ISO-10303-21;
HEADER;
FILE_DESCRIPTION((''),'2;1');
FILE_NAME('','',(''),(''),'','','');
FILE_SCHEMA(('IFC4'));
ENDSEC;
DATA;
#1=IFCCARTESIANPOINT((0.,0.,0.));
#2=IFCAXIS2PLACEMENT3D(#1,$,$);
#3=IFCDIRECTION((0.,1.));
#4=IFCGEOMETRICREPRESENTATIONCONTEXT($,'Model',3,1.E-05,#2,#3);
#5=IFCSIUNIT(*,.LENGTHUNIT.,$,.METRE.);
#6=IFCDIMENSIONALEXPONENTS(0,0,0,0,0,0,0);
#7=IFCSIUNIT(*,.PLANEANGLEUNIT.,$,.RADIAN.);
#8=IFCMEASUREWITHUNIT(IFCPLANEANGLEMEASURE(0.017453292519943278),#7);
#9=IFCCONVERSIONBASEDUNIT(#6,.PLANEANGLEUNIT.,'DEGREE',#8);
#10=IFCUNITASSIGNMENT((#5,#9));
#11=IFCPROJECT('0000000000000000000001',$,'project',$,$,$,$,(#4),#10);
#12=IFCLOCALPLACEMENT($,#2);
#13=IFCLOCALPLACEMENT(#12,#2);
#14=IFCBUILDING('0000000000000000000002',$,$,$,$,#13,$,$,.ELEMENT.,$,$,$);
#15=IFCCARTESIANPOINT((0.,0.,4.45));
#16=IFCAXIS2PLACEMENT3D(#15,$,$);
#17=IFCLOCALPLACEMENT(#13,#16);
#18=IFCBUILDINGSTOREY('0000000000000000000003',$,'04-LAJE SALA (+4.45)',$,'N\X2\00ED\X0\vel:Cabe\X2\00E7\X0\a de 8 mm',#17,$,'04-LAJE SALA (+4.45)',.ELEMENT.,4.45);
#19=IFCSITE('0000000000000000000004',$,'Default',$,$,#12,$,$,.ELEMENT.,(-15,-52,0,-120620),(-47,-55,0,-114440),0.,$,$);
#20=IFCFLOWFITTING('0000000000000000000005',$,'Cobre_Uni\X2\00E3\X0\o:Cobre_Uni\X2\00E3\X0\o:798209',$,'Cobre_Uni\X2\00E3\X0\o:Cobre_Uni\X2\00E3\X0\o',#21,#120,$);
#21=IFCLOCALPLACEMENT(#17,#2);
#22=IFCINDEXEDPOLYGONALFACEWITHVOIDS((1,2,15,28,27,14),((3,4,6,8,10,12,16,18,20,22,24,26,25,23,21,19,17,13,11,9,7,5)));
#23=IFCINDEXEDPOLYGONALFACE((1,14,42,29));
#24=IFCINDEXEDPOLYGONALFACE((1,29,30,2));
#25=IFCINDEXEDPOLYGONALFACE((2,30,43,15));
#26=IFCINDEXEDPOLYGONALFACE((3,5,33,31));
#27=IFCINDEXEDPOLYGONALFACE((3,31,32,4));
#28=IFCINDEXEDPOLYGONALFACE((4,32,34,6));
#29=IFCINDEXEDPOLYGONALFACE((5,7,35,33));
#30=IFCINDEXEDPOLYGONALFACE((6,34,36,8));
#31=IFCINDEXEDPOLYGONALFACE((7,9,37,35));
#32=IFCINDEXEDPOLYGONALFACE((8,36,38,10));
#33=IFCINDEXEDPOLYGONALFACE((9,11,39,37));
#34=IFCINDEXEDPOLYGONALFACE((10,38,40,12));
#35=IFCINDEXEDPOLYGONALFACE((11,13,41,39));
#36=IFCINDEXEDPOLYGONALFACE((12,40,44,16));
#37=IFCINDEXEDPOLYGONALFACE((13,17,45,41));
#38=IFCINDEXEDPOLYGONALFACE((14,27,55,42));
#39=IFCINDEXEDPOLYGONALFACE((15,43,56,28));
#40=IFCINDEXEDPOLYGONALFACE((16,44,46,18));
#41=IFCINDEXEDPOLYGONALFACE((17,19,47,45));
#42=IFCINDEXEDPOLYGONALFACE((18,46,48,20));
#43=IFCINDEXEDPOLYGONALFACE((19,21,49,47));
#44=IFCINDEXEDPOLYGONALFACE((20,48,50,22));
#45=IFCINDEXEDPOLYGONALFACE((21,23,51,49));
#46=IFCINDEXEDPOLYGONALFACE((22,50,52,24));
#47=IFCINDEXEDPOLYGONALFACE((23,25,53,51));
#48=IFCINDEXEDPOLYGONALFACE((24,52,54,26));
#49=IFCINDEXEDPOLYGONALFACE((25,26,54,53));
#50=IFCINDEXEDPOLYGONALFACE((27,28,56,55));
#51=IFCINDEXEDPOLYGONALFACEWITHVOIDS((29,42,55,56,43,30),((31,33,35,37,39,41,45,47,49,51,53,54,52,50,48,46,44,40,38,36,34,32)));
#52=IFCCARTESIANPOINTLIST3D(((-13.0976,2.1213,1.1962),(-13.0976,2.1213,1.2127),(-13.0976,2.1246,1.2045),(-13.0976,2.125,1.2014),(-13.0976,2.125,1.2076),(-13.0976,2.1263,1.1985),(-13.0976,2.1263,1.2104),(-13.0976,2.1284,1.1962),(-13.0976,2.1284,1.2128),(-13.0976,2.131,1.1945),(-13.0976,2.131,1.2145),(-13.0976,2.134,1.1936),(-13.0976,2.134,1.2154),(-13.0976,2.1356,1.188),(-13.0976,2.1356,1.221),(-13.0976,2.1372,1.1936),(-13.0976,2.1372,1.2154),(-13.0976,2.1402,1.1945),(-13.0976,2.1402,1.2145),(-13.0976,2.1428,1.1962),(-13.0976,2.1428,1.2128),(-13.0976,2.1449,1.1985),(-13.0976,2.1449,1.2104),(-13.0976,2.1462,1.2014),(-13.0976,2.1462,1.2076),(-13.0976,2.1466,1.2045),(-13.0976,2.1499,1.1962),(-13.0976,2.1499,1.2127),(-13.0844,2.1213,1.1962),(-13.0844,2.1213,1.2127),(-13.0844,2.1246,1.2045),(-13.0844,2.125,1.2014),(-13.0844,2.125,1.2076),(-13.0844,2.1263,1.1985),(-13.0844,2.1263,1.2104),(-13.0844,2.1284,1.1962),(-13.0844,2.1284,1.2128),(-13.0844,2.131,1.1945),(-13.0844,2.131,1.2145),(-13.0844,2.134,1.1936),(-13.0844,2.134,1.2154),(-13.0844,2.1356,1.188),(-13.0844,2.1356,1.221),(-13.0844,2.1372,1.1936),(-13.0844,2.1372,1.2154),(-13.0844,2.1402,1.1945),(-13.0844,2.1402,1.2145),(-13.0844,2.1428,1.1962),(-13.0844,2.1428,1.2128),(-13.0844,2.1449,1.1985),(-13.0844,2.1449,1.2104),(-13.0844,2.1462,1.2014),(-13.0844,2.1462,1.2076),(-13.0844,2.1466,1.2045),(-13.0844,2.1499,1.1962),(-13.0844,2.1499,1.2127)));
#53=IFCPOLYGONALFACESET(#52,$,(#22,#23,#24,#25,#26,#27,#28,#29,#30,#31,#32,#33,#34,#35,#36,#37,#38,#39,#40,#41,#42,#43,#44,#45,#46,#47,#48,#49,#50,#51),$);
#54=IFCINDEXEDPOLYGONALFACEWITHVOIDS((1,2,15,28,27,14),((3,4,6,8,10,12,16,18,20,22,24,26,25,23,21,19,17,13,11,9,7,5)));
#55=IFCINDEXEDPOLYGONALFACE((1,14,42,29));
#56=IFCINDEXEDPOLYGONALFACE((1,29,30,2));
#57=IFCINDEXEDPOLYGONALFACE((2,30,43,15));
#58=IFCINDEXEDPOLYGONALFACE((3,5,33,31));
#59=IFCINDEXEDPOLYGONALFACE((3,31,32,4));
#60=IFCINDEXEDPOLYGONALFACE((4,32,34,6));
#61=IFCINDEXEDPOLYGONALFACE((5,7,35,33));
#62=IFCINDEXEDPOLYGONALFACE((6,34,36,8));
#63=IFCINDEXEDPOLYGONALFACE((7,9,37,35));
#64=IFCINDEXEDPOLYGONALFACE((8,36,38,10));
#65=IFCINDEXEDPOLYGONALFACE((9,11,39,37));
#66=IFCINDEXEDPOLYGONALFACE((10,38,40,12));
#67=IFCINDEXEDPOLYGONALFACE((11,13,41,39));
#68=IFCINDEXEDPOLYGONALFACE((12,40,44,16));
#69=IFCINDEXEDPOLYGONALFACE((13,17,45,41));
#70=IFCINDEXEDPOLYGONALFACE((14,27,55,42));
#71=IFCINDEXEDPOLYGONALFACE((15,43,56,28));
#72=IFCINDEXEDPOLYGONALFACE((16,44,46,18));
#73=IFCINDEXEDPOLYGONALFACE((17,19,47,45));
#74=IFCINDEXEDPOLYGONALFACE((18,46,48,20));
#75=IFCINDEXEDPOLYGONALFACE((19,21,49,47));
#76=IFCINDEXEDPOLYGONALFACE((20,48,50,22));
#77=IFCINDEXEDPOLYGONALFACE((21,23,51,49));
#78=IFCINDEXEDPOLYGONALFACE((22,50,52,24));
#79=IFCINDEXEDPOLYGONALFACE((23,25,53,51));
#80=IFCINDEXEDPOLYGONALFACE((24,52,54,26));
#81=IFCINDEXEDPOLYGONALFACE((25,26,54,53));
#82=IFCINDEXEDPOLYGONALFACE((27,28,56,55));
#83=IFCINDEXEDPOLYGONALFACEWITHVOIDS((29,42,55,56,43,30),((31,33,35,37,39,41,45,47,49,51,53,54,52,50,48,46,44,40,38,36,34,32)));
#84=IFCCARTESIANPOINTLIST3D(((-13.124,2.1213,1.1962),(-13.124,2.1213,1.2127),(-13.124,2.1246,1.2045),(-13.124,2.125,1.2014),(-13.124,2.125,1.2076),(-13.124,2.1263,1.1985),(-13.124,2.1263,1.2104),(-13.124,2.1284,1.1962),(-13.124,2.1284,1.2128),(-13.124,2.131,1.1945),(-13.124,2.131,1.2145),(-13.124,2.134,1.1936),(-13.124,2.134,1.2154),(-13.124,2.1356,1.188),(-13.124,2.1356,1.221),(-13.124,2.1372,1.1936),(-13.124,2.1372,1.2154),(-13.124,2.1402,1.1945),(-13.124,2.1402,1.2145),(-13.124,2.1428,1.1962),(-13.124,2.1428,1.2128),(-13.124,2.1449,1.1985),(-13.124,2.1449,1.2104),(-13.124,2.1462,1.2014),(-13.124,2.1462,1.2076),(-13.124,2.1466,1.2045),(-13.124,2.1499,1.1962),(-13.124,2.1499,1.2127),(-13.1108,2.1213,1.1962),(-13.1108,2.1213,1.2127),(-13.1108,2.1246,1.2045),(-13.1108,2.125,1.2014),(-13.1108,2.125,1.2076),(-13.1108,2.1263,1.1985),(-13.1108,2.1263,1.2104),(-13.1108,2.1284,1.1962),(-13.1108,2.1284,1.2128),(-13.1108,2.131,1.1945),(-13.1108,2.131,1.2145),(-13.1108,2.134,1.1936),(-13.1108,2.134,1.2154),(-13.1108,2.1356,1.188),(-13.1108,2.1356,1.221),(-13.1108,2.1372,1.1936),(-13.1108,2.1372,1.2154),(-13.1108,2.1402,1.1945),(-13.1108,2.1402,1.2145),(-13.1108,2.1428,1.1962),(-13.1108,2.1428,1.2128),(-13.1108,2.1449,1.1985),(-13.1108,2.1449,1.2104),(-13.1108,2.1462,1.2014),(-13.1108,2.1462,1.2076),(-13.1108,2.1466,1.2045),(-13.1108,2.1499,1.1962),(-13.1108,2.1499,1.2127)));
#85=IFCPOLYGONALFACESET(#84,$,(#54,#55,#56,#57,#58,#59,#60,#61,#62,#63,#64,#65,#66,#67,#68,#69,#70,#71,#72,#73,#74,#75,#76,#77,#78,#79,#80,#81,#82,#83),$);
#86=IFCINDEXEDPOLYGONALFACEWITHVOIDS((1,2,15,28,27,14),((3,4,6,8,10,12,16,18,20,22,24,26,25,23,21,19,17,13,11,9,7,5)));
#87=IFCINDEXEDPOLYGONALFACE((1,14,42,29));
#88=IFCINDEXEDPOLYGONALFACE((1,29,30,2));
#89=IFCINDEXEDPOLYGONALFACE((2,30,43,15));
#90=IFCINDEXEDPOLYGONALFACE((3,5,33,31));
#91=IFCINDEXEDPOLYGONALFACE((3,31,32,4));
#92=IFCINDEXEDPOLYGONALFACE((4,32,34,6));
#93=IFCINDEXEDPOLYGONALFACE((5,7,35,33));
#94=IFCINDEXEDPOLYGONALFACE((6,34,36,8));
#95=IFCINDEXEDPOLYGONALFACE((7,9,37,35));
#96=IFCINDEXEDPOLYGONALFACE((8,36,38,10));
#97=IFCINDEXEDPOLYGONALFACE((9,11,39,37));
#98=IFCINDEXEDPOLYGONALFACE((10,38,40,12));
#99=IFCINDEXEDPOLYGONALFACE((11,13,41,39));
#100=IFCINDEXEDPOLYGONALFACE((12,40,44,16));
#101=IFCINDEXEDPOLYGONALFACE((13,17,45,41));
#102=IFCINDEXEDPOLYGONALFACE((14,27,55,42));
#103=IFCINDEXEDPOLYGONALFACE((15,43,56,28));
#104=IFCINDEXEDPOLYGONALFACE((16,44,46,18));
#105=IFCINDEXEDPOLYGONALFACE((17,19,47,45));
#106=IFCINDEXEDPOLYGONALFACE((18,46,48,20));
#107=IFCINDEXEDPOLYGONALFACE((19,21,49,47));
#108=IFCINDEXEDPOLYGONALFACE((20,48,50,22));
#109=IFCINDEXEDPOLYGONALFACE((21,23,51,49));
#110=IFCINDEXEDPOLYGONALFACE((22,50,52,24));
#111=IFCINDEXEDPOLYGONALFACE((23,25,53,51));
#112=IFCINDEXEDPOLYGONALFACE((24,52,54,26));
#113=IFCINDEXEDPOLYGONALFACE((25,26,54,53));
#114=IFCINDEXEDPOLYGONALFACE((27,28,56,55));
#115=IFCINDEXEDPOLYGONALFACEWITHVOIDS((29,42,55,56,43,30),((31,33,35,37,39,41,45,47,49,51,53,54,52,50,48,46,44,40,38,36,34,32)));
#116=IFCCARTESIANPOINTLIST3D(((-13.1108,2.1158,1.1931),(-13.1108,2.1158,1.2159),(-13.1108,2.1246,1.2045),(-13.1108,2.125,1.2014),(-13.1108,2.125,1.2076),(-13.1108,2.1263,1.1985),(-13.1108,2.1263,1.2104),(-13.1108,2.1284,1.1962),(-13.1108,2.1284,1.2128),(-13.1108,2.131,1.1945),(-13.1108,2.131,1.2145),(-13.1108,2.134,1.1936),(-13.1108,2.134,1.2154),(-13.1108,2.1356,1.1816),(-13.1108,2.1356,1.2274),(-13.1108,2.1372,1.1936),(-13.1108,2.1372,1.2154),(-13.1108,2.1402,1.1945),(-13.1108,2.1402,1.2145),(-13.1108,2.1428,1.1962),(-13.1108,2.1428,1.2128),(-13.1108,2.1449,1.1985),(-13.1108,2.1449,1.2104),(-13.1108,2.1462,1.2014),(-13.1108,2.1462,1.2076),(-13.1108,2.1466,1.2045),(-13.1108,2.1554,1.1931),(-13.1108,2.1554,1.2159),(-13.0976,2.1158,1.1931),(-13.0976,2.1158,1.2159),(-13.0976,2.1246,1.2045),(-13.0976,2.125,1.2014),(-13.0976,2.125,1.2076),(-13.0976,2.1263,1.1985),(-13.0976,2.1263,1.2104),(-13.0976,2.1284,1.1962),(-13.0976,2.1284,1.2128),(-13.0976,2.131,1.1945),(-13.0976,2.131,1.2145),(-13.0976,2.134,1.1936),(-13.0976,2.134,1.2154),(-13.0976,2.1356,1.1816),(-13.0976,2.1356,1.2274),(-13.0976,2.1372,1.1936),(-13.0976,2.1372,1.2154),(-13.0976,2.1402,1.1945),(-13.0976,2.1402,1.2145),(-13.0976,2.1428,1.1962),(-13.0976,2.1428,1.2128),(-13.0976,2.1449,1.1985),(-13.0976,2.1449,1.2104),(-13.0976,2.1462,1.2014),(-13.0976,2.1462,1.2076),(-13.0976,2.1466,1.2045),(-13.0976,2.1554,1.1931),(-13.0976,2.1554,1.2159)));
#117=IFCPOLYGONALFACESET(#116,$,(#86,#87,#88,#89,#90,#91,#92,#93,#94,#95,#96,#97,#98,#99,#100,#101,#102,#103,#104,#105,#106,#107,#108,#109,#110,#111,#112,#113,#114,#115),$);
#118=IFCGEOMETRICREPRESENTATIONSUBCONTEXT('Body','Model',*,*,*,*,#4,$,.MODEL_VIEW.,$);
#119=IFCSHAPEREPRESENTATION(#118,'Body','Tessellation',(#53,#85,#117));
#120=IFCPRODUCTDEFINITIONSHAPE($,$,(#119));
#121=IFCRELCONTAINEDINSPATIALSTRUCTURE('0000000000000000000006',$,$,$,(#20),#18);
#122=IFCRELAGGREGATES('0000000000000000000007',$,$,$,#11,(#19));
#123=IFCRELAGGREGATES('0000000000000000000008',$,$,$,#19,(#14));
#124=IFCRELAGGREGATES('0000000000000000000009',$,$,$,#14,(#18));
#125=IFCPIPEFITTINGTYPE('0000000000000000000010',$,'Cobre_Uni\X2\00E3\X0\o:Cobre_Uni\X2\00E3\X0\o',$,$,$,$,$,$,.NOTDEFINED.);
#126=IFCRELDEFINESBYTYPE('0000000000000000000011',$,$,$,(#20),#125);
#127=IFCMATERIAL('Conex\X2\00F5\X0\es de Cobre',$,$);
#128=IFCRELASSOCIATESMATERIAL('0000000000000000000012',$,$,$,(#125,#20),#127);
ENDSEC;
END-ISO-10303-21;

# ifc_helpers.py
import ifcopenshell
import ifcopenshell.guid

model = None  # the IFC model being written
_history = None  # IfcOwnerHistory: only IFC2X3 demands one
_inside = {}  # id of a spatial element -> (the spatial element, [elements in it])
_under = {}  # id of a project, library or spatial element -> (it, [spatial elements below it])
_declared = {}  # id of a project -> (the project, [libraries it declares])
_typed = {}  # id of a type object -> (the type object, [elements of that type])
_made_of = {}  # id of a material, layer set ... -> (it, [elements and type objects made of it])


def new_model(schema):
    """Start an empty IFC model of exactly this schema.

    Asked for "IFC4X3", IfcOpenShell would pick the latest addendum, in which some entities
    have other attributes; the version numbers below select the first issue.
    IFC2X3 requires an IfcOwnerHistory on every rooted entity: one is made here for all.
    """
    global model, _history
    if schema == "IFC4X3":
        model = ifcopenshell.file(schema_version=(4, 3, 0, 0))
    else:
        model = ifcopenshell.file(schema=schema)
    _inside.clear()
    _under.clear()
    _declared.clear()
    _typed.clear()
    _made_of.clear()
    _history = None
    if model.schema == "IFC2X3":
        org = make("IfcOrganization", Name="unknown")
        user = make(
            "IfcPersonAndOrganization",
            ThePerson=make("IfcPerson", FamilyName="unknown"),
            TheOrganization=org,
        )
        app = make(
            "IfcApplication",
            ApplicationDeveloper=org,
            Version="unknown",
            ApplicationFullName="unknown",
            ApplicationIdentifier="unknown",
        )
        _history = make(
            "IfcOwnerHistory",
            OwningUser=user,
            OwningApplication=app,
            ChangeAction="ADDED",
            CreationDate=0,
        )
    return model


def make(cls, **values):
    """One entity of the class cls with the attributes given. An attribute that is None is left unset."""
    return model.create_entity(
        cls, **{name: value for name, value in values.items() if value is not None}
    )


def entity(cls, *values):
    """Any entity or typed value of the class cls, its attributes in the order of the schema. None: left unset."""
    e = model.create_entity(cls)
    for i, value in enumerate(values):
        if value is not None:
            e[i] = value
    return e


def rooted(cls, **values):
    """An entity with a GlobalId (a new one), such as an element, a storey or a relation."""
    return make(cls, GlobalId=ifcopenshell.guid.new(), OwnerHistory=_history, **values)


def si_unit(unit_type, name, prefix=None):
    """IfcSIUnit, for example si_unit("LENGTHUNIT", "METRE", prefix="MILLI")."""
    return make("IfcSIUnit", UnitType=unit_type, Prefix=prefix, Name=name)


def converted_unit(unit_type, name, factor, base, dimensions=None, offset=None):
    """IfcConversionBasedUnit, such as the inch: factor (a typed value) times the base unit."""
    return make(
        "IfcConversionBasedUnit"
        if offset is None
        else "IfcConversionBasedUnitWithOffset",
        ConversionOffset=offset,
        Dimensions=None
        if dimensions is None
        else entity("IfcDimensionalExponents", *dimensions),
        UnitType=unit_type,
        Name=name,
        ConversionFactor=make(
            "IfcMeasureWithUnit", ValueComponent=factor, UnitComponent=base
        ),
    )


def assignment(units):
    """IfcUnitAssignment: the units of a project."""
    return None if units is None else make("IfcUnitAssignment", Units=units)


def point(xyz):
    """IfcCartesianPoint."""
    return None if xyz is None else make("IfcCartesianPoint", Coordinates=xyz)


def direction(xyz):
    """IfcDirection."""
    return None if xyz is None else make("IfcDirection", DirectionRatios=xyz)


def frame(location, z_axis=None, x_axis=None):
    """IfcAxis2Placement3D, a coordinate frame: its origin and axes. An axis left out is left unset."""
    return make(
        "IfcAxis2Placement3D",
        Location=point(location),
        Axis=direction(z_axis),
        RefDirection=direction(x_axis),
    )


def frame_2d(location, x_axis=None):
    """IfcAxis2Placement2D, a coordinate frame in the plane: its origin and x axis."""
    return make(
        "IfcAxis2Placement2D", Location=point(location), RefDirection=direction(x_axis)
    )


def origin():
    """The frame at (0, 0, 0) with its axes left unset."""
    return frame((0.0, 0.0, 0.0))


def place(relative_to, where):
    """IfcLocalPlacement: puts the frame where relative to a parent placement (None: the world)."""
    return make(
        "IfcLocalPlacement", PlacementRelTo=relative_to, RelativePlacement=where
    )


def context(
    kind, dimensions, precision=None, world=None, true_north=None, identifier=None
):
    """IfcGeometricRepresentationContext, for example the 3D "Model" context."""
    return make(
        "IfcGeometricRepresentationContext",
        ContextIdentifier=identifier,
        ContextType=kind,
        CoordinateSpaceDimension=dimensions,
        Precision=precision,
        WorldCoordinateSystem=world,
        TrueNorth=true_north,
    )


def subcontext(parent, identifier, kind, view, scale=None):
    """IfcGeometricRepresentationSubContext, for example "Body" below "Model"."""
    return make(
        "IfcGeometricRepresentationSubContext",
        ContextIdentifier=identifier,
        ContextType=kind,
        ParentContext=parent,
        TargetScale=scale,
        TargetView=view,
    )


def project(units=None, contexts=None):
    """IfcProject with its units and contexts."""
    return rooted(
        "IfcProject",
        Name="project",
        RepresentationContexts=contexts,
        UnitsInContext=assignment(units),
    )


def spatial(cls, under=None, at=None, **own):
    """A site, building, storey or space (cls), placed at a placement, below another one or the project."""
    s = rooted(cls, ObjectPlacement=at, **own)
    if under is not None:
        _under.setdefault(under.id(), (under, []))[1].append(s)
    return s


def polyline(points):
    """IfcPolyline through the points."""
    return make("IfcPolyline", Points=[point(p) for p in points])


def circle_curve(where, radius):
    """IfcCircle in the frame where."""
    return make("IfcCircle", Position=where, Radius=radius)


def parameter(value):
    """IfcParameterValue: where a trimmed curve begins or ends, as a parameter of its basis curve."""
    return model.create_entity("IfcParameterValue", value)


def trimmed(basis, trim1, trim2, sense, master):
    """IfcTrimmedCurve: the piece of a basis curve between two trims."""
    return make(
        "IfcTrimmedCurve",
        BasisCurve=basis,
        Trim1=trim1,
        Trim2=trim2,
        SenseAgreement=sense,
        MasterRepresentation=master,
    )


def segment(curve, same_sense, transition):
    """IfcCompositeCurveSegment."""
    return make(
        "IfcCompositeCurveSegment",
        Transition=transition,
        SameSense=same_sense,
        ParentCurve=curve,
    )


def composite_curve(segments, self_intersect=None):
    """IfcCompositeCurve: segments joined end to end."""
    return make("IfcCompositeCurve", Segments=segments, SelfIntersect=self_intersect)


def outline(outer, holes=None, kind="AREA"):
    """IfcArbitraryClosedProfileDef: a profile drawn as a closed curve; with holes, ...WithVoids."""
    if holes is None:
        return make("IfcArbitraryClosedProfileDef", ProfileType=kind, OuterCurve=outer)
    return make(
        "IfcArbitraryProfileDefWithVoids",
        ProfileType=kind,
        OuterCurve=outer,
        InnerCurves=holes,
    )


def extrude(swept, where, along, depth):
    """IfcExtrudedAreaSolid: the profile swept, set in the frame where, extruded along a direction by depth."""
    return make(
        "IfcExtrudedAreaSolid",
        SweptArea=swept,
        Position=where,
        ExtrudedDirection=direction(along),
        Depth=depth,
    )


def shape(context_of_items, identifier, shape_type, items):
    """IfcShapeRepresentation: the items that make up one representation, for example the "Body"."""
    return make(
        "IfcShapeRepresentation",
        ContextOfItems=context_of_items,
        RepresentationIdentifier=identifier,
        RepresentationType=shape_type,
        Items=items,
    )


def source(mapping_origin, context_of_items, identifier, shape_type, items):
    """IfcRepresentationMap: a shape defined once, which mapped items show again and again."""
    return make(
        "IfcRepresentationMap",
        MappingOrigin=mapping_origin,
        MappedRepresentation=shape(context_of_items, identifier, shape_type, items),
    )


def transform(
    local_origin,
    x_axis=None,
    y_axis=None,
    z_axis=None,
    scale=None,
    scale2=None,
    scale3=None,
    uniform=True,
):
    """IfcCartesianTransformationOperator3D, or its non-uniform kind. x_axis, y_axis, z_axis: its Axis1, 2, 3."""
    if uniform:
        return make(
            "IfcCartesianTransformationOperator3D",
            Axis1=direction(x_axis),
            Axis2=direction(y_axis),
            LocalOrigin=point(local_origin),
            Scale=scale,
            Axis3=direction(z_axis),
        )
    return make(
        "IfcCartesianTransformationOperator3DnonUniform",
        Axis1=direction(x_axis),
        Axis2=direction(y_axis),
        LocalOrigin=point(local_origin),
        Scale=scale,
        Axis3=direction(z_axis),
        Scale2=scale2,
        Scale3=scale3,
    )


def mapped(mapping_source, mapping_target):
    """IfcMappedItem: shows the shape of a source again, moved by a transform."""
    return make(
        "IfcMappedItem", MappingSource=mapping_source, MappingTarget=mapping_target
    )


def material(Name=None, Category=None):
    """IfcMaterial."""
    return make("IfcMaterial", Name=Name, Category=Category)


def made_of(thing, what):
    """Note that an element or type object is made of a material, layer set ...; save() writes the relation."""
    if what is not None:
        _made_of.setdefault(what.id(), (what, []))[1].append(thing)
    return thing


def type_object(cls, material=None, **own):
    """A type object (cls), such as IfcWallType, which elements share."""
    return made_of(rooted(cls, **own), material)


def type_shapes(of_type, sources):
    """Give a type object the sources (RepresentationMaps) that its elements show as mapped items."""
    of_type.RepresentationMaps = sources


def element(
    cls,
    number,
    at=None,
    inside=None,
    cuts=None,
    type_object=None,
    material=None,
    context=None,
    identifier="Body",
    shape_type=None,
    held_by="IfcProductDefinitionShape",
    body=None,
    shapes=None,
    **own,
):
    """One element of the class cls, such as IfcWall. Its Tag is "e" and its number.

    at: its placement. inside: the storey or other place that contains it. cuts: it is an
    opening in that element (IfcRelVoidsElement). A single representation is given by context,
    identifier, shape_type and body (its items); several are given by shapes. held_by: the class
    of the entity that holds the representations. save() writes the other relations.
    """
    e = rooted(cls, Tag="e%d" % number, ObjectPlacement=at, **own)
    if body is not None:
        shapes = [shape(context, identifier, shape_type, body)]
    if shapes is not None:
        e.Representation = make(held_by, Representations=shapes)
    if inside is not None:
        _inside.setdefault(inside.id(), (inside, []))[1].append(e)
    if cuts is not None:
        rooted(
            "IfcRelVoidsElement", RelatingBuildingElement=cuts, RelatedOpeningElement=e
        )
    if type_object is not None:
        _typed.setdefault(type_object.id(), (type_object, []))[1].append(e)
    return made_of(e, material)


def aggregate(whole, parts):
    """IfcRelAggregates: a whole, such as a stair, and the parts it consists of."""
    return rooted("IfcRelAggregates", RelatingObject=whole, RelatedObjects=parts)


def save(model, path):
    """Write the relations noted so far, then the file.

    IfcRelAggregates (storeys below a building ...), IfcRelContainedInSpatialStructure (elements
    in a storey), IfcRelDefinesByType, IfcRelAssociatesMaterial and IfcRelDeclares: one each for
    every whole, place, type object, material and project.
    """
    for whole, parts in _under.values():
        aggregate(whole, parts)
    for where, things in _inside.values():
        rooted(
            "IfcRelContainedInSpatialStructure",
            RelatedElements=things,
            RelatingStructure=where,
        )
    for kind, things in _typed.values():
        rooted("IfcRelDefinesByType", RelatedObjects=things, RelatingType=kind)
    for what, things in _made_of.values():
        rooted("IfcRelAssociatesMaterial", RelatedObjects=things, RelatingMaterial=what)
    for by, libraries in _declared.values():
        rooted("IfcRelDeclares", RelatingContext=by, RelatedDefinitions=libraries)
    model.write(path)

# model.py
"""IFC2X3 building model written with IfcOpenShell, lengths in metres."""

from ifc_helpers import new_model, entity, si_unit, converted_unit, direction, frame, frame_2d, origin, place, context, subcontext, project, spatial, polyline, circle_curve, parameter, trimmed, segment, composite_curve, outline, extrude, source, transform, mapped, material, type_object, type_shapes, element, save


model = new_model("IFC2X3")

# Units and contexts
model_context = context("Model", 3, precision=1e-05, world=origin(), true_north=direction((0.0, 1.0)))
body_context = subcontext(model_context, "Body", "Model", "MODEL_VIEW")
ifc_project = project(units=[si_unit("LENGTHUNIT", "METRE"), converted_unit("PLANEANGLEUNIT", "DEGREE", entity("IfcPlaneAngleMeasure", 0.017453292519943278), si_unit("PLANEANGLEUNIT", "RADIAN"), dimensions=[0, 0, 0, 0, 0, 0, 0])], contexts=[model_context])

# Site, building, storey
site_placement = place(None, origin())
site = spatial("IfcSite", under=ifc_project, at=site_placement, Name="Default", CompositionType="ELEMENT", RefLatitude=(-15, -52, 0, -120620), RefLongitude=(-47, -55, 0, -114440), RefElevation=0.0)
building_placement = place(site_placement, origin())
building = spatial("IfcBuilding", under=site, at=building_placement, CompositionType="ELEMENT")
storey_placement = place(building_placement, frame((0.0, 0.0, 4.45)))
storey = spatial("IfcBuildingStorey", under=building, at=storey_placement, Name="04-LAJE SALA (+4.45)", ObjectType="Nível:Cabeça de 8 mm", LongName="04-LAJE SALA (+4.45)", CompositionType="ELEMENT", Elevation=4.45)

# Flow fitting
ifc_material_1 = material(Name="Conexões de Cobre")
pipe_fitting_type_1 = type_object("IfcPipeFittingType", Name="Cobre_União:Cobre_União", PredefinedType="NOTDEFINED", material=ifc_material_1)
shared_shape_1 = source(origin(), body_context, "Body", "SweptSolid", [
    extrude(outline(polyline([(-0.0083, -0.0143), (0.0083, -0.0143), (0.0165, 0.0), (0.0083, 0.0143), (-0.0083, 0.0143), (-0.0165, 0.0), (-0.0083, -0.0143)]), holes=[composite_curve([segment(trimmed(circle_curve(frame_2d((0.0, 0.0), x_axis=(0.0, 1.0)), 0.011), [parameter(0.0)], [parameter(180.0)], True, "PARAMETER"), False, "CONTINUOUS"), segment(trimmed(circle_curve(frame_2d((0.0, 0.0), x_axis=(0.0, 1.0)), 0.011), [parameter(180.0)], [parameter(0.0)], True, "PARAMETER"), False, "CONTINUOUS")], self_intersect=False)]), frame((0.0264, 0.0, 0.0), z_axis=(1.0, 0.0, 0.0), x_axis=(0.0, 0.0, -1.0)), (0.0, 0.0, 1.0), 0.0132),
    extrude(outline(polyline([(-0.0083, -0.0143), (0.0083, -0.0143), (0.0165, 0.0), (0.0083, 0.0143), (-0.0083, 0.0143), (-0.0165, 0.0), (-0.0083, -0.0143)]), holes=[composite_curve([segment(trimmed(circle_curve(frame_2d((0.0, 0.0), x_axis=(0.0, 1.0)), 0.011), [parameter(0.0)], [parameter(180.0)], True, "PARAMETER"), False, "CONTINUOUS"), segment(trimmed(circle_curve(frame_2d((0.0, 0.0), x_axis=(0.0, 1.0)), 0.011), [parameter(180.0)], [parameter(0.0)], True, "PARAMETER"), False, "CONTINUOUS")], self_intersect=False)]), frame((0.0, 0.0, 0.0), z_axis=(1.0, 0.0, 0.0), x_axis=(0.0, 0.0, -1.0)), (0.0, 0.0, 1.0), 0.0132),
    extrude(outline(polyline([(-0.0114, -0.0198), (0.0114, -0.0198), (0.0229, 0.0), (0.0114, 0.0198), (-0.0114, 0.0198), (-0.0229, 0.0), (-0.0114, -0.0198)]), holes=[composite_curve([segment(trimmed(circle_curve(frame_2d((0.0, 0.0), x_axis=(0.0, 1.0)), 0.011), [parameter(0.0)], [parameter(180.0)], True, "PARAMETER"), False, "CONTINUOUS"), segment(trimmed(circle_curve(frame_2d((0.0, 0.0), x_axis=(0.0, 1.0)), 0.011), [parameter(180.0)], [parameter(0.0)], True, "PARAMETER"), False, "CONTINUOUS")], self_intersect=False)]), frame((0.0132, 0.0, 0.0), z_axis=(1.0, 0.0, 0.0), x_axis=(0.0, 0.0, -1.0)), (0.0, 0.0, 1.0), 0.0132),
])
type_shapes(pipe_fitting_type_1, [shared_shape_1])
flow_fitting_1_placement = place(storey_placement, frame((-13.124, 2.1356, 1.2045)))
element("IfcFlowFitting", 1, at=flow_fitting_1_placement, inside=storey, type_object=pipe_fitting_type_1, material=ifc_material_1, Name="Cobre_União:Cobre_União:798209", ObjectType="Cobre_União:Cobre_União", context=body_context, shape_type="MappedRepresentation", body=[
    mapped(shared_shape_1, transform((0.0, 0.0, 0.0), scale=1.0)),
])

save(model, "model.ifc")
